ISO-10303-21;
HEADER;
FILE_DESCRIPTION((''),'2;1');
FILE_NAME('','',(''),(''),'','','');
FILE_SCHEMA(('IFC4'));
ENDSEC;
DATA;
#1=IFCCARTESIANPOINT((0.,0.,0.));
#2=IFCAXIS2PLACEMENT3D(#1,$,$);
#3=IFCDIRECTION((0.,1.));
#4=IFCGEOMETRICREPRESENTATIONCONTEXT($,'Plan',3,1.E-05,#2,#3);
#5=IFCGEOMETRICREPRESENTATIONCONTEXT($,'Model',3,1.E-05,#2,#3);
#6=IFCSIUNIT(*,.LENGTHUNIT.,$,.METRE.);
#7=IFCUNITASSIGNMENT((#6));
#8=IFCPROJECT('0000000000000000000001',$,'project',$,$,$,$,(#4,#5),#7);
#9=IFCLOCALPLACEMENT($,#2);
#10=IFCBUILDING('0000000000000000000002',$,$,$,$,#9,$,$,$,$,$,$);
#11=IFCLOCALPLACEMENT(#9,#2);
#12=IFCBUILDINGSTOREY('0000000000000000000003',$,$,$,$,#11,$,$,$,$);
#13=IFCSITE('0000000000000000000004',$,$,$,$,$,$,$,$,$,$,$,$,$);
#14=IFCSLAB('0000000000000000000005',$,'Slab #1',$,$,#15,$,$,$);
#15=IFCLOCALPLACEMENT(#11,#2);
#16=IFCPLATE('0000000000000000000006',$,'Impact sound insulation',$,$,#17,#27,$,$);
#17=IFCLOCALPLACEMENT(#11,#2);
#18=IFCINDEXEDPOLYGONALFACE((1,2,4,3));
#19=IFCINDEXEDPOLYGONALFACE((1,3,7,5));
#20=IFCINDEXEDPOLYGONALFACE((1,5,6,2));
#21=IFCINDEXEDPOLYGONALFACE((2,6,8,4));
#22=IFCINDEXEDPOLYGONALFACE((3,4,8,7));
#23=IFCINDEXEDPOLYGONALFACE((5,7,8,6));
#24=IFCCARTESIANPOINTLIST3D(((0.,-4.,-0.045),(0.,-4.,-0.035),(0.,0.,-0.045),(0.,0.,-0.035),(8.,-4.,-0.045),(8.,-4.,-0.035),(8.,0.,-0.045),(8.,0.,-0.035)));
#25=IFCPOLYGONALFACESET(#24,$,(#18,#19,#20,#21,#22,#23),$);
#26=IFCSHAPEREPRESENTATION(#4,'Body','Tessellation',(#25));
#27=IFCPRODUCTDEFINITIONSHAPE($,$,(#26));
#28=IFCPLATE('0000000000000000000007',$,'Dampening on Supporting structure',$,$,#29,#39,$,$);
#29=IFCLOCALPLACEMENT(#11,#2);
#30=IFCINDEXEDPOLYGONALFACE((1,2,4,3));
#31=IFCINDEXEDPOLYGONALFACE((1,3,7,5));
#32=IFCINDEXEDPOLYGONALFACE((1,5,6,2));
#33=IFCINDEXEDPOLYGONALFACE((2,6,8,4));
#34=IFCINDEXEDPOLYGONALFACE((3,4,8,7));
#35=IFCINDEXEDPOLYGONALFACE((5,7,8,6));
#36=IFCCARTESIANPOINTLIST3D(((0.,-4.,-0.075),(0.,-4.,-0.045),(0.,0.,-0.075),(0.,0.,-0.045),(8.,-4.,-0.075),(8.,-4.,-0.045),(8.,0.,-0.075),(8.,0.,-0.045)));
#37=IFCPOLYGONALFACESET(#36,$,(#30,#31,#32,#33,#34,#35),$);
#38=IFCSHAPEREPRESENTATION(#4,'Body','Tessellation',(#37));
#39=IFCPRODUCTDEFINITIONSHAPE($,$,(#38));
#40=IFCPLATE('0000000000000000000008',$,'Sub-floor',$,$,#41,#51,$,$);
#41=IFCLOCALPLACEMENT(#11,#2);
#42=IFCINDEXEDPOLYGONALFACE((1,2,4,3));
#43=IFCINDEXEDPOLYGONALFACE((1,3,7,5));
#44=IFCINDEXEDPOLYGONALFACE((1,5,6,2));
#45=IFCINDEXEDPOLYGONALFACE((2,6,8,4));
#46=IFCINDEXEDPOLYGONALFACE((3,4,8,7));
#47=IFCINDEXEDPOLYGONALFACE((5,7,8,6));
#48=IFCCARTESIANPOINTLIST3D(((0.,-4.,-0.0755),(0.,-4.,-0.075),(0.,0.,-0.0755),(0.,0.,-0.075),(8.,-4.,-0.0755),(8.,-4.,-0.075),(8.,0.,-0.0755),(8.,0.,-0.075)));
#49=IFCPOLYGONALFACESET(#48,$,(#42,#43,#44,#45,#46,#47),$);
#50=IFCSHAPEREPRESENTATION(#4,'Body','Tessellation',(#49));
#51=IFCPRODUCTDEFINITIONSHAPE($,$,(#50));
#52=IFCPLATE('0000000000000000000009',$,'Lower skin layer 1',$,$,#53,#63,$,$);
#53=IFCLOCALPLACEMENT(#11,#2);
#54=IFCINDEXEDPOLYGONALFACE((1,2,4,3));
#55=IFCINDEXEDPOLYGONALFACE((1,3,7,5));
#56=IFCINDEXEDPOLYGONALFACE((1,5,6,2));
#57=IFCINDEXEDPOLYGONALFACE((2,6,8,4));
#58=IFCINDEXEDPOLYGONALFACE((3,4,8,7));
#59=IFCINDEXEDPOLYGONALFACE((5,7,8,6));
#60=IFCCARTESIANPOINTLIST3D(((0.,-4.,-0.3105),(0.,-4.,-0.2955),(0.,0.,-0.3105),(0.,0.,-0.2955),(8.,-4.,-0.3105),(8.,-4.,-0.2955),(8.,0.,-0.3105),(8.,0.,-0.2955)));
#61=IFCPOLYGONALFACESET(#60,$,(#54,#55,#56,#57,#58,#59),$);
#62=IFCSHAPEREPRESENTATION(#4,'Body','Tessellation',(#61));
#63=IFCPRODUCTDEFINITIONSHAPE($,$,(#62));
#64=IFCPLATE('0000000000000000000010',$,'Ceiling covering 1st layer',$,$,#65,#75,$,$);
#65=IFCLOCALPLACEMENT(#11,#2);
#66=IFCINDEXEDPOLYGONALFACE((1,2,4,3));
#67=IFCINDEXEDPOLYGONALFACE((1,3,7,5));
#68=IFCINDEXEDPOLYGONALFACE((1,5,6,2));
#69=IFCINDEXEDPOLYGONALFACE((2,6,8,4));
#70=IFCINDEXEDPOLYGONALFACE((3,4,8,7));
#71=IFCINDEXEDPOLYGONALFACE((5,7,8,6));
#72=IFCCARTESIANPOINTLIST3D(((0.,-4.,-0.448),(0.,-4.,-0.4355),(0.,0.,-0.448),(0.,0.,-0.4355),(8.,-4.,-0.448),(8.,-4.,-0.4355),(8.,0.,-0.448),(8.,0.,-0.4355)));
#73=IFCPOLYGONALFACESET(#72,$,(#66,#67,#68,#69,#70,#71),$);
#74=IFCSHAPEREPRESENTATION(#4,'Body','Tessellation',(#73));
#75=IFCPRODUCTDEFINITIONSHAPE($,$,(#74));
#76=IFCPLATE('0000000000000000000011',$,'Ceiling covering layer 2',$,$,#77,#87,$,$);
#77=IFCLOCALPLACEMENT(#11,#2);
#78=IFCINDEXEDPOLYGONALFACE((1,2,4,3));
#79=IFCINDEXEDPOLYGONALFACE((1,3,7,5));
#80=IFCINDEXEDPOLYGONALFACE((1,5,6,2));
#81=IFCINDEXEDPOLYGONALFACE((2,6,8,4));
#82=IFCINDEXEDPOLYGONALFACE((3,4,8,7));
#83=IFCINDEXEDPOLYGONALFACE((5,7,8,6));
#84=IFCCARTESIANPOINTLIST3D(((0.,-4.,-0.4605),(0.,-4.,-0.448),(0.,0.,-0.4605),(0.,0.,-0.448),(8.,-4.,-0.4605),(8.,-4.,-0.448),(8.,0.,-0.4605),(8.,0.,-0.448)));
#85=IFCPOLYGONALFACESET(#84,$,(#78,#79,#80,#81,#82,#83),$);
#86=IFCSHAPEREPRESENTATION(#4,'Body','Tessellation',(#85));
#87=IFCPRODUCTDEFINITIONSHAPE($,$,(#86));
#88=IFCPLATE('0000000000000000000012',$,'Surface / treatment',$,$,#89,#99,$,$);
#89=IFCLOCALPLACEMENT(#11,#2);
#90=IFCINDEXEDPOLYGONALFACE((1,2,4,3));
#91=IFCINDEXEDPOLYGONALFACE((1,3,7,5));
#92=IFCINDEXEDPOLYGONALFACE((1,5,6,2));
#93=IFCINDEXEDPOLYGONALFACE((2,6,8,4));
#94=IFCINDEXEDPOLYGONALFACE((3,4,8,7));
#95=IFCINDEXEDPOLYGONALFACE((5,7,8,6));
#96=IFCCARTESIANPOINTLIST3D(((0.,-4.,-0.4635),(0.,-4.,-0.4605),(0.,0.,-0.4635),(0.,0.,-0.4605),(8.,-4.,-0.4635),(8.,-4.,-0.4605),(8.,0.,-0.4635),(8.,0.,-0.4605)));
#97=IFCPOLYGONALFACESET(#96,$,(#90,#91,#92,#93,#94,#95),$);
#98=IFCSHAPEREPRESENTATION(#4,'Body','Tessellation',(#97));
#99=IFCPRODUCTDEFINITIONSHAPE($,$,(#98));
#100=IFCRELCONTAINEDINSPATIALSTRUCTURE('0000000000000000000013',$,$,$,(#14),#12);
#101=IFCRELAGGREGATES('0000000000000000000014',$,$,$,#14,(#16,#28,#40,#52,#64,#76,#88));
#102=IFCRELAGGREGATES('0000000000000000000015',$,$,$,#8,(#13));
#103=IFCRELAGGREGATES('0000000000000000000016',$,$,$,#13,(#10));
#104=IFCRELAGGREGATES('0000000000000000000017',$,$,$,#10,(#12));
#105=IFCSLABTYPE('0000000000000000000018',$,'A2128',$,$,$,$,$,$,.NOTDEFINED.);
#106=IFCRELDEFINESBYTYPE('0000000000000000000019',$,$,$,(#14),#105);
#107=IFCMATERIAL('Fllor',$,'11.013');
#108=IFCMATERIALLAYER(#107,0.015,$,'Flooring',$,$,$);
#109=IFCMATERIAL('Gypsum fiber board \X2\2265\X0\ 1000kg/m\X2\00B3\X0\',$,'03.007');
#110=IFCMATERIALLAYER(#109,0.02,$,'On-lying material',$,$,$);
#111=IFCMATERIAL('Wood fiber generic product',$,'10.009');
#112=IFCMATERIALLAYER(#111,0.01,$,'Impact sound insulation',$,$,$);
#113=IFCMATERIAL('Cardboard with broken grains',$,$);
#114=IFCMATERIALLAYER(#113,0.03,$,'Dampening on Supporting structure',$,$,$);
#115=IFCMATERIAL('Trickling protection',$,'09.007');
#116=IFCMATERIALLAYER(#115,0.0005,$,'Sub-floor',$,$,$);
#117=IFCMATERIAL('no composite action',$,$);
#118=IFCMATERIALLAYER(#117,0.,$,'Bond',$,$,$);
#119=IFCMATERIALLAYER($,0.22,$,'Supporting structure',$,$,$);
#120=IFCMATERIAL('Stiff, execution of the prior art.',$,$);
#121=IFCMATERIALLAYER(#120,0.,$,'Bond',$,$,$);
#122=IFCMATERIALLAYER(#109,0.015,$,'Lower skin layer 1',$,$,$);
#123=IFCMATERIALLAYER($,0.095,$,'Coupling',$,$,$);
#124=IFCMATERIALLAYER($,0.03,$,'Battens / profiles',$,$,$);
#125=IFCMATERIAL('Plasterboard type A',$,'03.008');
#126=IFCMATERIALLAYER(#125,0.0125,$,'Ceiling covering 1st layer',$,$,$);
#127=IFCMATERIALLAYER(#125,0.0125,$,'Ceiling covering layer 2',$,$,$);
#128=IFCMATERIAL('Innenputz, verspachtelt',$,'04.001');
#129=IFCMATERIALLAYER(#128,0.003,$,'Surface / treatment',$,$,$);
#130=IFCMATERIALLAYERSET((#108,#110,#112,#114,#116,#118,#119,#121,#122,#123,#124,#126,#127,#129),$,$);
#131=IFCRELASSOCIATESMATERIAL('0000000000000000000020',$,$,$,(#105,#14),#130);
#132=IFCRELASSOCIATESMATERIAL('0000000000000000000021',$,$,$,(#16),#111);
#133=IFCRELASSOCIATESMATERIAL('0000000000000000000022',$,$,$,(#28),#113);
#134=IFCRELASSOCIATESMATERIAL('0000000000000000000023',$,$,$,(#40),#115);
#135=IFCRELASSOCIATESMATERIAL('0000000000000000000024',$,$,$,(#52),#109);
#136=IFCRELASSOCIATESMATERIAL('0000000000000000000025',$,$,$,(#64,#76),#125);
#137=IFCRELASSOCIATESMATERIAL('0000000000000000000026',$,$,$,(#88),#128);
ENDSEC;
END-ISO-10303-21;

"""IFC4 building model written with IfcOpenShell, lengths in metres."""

from ifc_helpers import new_model, si_unit, direction, frame, frame_2d, origin, place, context, project, spatial, rectangle, extrude, material, layer, layer_set, type_object, element, aggregate, save


model = new_model("IFC4")

# Units and contexts
plan_context = context("Plan", 3, precision=1e-05, world=origin(), true_north=direction((0.0, 1.0)))
model_context = context("Model", 3, precision=1e-05, world=origin(), true_north=direction((0.0, 1.0)))
ifc_project = project(units=[si_unit("LENGTHUNIT", "METRE")], contexts=[plan_context, model_context])

# Site, building, storey
site = spatial("IfcSite", under=ifc_project)
building_placement = place(None, origin())
building = spatial("IfcBuilding", under=site, at=building_placement)
storey_placement = place(building_placement, origin())
storey = spatial("IfcBuildingStorey", under=building, at=storey_placement)

# Slab, plates
ifc_material_1 = material(Name="Fllor", Category="11.013")
ifc_layer_1 = layer(ifc_material_1, 0.015, Name="Flooring")
ifc_material_2 = material(Name="Gypsum fiber board ≥ 1000kg/m³", Category="03.007")
ifc_layer_2 = layer(ifc_material_2, 0.02, Name="On-lying material")
ifc_material_3 = material(Name="Wood fiber generic product", Category="10.009")
ifc_layer_3 = layer(ifc_material_3, 0.01, Name="Impact sound insulation")
ifc_material_4 = material(Name="Cardboard with broken grains")
ifc_layer_4 = layer(ifc_material_4, 0.03, Name="Dampening on Supporting structure")
ifc_material_5 = material(Name="Trickling protection", Category="09.007")
ifc_layer_5 = layer(ifc_material_5, 0.0005, Name="Sub-floor")
ifc_material_6 = material(Name="no composite action")
ifc_layer_6 = layer(ifc_material_6, 0.0, Name="Bond")
ifc_layer_7 = layer(None, 0.22, Name="Supporting structure")
ifc_material_7 = material(Name="Stiff, execution of the prior art.")
ifc_layer_8 = layer(ifc_material_7, 0.0, Name="Bond")
ifc_layer_9 = layer(ifc_material_2, 0.015, Name="Lower skin layer 1")
ifc_layer_10 = layer(None, 0.095, Name="Coupling")
ifc_layer_11 = layer(None, 0.03, Name="Battens / profiles")
ifc_material_8 = material(Name="Plasterboard type A", Category="03.008")
ifc_layer_12 = layer(ifc_material_8, 0.0125, Name="Ceiling covering 1st layer")
ifc_layer_13 = layer(ifc_material_8, 0.0125, Name="Ceiling covering layer 2")
ifc_material_9 = material(Name="Innenputz, verspachtelt", Category="04.001")
ifc_layer_14 = layer(ifc_material_9, 0.003, Name="Surface / treatment")
ifc_layer_set = layer_set([ifc_layer_1, ifc_layer_2, ifc_layer_3, ifc_layer_4, ifc_layer_5, ifc_layer_6, ifc_layer_7, ifc_layer_8, ifc_layer_9, ifc_layer_10, ifc_layer_11, ifc_layer_12, ifc_layer_13, ifc_layer_14])
slab_type = type_object("IfcSlabType", Name="A2128", PredefinedType="NOTDEFINED", material=ifc_layer_set)
slab_placement = place(None, frame((0.0, 0.0, 0.0), z_axis=(0.0, 0.0, -1.0), x_axis=(1.0, 0.0, 0.0)))
slab = element("IfcSlab", 1, at=slab_placement, inside=storey, type_object=slab_type, material=ifc_layer_set, Name="Slab #1")
plate_1_placement = place(slab_placement, origin())
plate_1 = element("IfcPlate", 2, at=plate_1_placement, material=ifc_material_3, Name="Impact sound insulation", context=plan_context, shape_type="SweptSolid", body=[
    extrude(rectangle(XDim=8.0, YDim=4.0, at=frame_2d((4.0, 2.0), x_axis=(1.0, 0.0))), frame((0.0, 0.0, 0.035), z_axis=(0.0, 0.0, 1.0), x_axis=(1.0, 0.0, 0.0)), (0.0, 0.0, 1.0), 0.01),
])
plate_2_placement = place(slab_placement, origin())
plate_2 = element("IfcPlate", 3, at=plate_2_placement, material=ifc_material_4, Name="Dampening on Supporting structure", context=plan_context, shape_type="SweptSolid", body=[
    extrude(rectangle(XDim=8.0, YDim=4.0, at=frame_2d((4.0, 2.0), x_axis=(1.0, 0.0))), frame((0.0, 0.0, 0.045), z_axis=(0.0, 0.0, 1.0), x_axis=(1.0, 0.0, 0.0)), (0.0, 0.0, 1.0), 0.03),
])
plate_3_placement = place(slab_placement, origin())
plate_3 = element("IfcPlate", 4, at=plate_3_placement, material=ifc_material_5, Name="Sub-floor", context=plan_context, shape_type="SweptSolid", body=[
    extrude(rectangle(XDim=8.0, YDim=4.0, at=frame_2d((4.0, 2.0), x_axis=(1.0, 0.0))), frame((0.0, 0.0, 0.075), z_axis=(0.0, 0.0, 1.0), x_axis=(1.0, 0.0, 0.0)), (0.0, 0.0, 1.0), 0.0005),
])
plate_4_placement = place(slab_placement, origin())
plate_4 = element("IfcPlate", 5, at=plate_4_placement, material=ifc_material_2, Name="Lower skin layer 1", context=plan_context, shape_type="SweptSolid", body=[
    extrude(rectangle(XDim=8.0, YDim=4.0, at=frame_2d((4.0, 2.0), x_axis=(1.0, 0.0))), frame((0.0, 0.0, 0.2955), z_axis=(0.0, 0.0, 1.0), x_axis=(1.0, 0.0, 0.0)), (0.0, 0.0, 1.0), 0.015),
])
plate_5_placement = place(slab_placement, origin())
plate_5 = element("IfcPlate", 6, at=plate_5_placement, material=ifc_material_8, Name="Ceiling covering 1st layer", context=plan_context, shape_type="SweptSolid", body=[
    extrude(rectangle(XDim=8.0, YDim=4.0, at=frame_2d((4.0, 2.0), x_axis=(1.0, 0.0))), frame((0.0, 0.0, 0.4355), z_axis=(0.0, 0.0, 1.0), x_axis=(1.0, 0.0, 0.0)), (0.0, 0.0, 1.0), 0.0125),
])
plate_6_placement = place(slab_placement, origin())
plate_6 = element("IfcPlate", 7, at=plate_6_placement, material=ifc_material_8, Name="Ceiling covering layer 2", context=plan_context, shape_type="SweptSolid", body=[
    extrude(rectangle(XDim=8.0, YDim=4.0, at=frame_2d((4.0, 2.0), x_axis=(1.0, 0.0))), frame((0.0, 0.0, 0.448), z_axis=(0.0, 0.0, 1.0), x_axis=(1.0, 0.0, 0.0)), (0.0, 0.0, 1.0), 0.0125),
])
plate_7_placement = place(slab_placement, origin())
plate_7 = element("IfcPlate", 8, at=plate_7_placement, material=ifc_material_9, Name="Surface / treatment", context=plan_context, shape_type="SweptSolid", body=[
    extrude(rectangle(XDim=8.0, YDim=4.0, at=frame_2d((4.0, 2.0), x_axis=(1.0, 0.0))), frame((0.0, 0.0, 0.4605), z_axis=(0.0, 0.0, 1.0), x_axis=(1.0, 0.0, 0.0)), (0.0, 0.0, 1.0), 0.003),
])
aggregate(slab, [plate_1, plate_2, plate_3, plate_4, plate_5, plate_6, plate_7])

save(model, "model.ifc")
